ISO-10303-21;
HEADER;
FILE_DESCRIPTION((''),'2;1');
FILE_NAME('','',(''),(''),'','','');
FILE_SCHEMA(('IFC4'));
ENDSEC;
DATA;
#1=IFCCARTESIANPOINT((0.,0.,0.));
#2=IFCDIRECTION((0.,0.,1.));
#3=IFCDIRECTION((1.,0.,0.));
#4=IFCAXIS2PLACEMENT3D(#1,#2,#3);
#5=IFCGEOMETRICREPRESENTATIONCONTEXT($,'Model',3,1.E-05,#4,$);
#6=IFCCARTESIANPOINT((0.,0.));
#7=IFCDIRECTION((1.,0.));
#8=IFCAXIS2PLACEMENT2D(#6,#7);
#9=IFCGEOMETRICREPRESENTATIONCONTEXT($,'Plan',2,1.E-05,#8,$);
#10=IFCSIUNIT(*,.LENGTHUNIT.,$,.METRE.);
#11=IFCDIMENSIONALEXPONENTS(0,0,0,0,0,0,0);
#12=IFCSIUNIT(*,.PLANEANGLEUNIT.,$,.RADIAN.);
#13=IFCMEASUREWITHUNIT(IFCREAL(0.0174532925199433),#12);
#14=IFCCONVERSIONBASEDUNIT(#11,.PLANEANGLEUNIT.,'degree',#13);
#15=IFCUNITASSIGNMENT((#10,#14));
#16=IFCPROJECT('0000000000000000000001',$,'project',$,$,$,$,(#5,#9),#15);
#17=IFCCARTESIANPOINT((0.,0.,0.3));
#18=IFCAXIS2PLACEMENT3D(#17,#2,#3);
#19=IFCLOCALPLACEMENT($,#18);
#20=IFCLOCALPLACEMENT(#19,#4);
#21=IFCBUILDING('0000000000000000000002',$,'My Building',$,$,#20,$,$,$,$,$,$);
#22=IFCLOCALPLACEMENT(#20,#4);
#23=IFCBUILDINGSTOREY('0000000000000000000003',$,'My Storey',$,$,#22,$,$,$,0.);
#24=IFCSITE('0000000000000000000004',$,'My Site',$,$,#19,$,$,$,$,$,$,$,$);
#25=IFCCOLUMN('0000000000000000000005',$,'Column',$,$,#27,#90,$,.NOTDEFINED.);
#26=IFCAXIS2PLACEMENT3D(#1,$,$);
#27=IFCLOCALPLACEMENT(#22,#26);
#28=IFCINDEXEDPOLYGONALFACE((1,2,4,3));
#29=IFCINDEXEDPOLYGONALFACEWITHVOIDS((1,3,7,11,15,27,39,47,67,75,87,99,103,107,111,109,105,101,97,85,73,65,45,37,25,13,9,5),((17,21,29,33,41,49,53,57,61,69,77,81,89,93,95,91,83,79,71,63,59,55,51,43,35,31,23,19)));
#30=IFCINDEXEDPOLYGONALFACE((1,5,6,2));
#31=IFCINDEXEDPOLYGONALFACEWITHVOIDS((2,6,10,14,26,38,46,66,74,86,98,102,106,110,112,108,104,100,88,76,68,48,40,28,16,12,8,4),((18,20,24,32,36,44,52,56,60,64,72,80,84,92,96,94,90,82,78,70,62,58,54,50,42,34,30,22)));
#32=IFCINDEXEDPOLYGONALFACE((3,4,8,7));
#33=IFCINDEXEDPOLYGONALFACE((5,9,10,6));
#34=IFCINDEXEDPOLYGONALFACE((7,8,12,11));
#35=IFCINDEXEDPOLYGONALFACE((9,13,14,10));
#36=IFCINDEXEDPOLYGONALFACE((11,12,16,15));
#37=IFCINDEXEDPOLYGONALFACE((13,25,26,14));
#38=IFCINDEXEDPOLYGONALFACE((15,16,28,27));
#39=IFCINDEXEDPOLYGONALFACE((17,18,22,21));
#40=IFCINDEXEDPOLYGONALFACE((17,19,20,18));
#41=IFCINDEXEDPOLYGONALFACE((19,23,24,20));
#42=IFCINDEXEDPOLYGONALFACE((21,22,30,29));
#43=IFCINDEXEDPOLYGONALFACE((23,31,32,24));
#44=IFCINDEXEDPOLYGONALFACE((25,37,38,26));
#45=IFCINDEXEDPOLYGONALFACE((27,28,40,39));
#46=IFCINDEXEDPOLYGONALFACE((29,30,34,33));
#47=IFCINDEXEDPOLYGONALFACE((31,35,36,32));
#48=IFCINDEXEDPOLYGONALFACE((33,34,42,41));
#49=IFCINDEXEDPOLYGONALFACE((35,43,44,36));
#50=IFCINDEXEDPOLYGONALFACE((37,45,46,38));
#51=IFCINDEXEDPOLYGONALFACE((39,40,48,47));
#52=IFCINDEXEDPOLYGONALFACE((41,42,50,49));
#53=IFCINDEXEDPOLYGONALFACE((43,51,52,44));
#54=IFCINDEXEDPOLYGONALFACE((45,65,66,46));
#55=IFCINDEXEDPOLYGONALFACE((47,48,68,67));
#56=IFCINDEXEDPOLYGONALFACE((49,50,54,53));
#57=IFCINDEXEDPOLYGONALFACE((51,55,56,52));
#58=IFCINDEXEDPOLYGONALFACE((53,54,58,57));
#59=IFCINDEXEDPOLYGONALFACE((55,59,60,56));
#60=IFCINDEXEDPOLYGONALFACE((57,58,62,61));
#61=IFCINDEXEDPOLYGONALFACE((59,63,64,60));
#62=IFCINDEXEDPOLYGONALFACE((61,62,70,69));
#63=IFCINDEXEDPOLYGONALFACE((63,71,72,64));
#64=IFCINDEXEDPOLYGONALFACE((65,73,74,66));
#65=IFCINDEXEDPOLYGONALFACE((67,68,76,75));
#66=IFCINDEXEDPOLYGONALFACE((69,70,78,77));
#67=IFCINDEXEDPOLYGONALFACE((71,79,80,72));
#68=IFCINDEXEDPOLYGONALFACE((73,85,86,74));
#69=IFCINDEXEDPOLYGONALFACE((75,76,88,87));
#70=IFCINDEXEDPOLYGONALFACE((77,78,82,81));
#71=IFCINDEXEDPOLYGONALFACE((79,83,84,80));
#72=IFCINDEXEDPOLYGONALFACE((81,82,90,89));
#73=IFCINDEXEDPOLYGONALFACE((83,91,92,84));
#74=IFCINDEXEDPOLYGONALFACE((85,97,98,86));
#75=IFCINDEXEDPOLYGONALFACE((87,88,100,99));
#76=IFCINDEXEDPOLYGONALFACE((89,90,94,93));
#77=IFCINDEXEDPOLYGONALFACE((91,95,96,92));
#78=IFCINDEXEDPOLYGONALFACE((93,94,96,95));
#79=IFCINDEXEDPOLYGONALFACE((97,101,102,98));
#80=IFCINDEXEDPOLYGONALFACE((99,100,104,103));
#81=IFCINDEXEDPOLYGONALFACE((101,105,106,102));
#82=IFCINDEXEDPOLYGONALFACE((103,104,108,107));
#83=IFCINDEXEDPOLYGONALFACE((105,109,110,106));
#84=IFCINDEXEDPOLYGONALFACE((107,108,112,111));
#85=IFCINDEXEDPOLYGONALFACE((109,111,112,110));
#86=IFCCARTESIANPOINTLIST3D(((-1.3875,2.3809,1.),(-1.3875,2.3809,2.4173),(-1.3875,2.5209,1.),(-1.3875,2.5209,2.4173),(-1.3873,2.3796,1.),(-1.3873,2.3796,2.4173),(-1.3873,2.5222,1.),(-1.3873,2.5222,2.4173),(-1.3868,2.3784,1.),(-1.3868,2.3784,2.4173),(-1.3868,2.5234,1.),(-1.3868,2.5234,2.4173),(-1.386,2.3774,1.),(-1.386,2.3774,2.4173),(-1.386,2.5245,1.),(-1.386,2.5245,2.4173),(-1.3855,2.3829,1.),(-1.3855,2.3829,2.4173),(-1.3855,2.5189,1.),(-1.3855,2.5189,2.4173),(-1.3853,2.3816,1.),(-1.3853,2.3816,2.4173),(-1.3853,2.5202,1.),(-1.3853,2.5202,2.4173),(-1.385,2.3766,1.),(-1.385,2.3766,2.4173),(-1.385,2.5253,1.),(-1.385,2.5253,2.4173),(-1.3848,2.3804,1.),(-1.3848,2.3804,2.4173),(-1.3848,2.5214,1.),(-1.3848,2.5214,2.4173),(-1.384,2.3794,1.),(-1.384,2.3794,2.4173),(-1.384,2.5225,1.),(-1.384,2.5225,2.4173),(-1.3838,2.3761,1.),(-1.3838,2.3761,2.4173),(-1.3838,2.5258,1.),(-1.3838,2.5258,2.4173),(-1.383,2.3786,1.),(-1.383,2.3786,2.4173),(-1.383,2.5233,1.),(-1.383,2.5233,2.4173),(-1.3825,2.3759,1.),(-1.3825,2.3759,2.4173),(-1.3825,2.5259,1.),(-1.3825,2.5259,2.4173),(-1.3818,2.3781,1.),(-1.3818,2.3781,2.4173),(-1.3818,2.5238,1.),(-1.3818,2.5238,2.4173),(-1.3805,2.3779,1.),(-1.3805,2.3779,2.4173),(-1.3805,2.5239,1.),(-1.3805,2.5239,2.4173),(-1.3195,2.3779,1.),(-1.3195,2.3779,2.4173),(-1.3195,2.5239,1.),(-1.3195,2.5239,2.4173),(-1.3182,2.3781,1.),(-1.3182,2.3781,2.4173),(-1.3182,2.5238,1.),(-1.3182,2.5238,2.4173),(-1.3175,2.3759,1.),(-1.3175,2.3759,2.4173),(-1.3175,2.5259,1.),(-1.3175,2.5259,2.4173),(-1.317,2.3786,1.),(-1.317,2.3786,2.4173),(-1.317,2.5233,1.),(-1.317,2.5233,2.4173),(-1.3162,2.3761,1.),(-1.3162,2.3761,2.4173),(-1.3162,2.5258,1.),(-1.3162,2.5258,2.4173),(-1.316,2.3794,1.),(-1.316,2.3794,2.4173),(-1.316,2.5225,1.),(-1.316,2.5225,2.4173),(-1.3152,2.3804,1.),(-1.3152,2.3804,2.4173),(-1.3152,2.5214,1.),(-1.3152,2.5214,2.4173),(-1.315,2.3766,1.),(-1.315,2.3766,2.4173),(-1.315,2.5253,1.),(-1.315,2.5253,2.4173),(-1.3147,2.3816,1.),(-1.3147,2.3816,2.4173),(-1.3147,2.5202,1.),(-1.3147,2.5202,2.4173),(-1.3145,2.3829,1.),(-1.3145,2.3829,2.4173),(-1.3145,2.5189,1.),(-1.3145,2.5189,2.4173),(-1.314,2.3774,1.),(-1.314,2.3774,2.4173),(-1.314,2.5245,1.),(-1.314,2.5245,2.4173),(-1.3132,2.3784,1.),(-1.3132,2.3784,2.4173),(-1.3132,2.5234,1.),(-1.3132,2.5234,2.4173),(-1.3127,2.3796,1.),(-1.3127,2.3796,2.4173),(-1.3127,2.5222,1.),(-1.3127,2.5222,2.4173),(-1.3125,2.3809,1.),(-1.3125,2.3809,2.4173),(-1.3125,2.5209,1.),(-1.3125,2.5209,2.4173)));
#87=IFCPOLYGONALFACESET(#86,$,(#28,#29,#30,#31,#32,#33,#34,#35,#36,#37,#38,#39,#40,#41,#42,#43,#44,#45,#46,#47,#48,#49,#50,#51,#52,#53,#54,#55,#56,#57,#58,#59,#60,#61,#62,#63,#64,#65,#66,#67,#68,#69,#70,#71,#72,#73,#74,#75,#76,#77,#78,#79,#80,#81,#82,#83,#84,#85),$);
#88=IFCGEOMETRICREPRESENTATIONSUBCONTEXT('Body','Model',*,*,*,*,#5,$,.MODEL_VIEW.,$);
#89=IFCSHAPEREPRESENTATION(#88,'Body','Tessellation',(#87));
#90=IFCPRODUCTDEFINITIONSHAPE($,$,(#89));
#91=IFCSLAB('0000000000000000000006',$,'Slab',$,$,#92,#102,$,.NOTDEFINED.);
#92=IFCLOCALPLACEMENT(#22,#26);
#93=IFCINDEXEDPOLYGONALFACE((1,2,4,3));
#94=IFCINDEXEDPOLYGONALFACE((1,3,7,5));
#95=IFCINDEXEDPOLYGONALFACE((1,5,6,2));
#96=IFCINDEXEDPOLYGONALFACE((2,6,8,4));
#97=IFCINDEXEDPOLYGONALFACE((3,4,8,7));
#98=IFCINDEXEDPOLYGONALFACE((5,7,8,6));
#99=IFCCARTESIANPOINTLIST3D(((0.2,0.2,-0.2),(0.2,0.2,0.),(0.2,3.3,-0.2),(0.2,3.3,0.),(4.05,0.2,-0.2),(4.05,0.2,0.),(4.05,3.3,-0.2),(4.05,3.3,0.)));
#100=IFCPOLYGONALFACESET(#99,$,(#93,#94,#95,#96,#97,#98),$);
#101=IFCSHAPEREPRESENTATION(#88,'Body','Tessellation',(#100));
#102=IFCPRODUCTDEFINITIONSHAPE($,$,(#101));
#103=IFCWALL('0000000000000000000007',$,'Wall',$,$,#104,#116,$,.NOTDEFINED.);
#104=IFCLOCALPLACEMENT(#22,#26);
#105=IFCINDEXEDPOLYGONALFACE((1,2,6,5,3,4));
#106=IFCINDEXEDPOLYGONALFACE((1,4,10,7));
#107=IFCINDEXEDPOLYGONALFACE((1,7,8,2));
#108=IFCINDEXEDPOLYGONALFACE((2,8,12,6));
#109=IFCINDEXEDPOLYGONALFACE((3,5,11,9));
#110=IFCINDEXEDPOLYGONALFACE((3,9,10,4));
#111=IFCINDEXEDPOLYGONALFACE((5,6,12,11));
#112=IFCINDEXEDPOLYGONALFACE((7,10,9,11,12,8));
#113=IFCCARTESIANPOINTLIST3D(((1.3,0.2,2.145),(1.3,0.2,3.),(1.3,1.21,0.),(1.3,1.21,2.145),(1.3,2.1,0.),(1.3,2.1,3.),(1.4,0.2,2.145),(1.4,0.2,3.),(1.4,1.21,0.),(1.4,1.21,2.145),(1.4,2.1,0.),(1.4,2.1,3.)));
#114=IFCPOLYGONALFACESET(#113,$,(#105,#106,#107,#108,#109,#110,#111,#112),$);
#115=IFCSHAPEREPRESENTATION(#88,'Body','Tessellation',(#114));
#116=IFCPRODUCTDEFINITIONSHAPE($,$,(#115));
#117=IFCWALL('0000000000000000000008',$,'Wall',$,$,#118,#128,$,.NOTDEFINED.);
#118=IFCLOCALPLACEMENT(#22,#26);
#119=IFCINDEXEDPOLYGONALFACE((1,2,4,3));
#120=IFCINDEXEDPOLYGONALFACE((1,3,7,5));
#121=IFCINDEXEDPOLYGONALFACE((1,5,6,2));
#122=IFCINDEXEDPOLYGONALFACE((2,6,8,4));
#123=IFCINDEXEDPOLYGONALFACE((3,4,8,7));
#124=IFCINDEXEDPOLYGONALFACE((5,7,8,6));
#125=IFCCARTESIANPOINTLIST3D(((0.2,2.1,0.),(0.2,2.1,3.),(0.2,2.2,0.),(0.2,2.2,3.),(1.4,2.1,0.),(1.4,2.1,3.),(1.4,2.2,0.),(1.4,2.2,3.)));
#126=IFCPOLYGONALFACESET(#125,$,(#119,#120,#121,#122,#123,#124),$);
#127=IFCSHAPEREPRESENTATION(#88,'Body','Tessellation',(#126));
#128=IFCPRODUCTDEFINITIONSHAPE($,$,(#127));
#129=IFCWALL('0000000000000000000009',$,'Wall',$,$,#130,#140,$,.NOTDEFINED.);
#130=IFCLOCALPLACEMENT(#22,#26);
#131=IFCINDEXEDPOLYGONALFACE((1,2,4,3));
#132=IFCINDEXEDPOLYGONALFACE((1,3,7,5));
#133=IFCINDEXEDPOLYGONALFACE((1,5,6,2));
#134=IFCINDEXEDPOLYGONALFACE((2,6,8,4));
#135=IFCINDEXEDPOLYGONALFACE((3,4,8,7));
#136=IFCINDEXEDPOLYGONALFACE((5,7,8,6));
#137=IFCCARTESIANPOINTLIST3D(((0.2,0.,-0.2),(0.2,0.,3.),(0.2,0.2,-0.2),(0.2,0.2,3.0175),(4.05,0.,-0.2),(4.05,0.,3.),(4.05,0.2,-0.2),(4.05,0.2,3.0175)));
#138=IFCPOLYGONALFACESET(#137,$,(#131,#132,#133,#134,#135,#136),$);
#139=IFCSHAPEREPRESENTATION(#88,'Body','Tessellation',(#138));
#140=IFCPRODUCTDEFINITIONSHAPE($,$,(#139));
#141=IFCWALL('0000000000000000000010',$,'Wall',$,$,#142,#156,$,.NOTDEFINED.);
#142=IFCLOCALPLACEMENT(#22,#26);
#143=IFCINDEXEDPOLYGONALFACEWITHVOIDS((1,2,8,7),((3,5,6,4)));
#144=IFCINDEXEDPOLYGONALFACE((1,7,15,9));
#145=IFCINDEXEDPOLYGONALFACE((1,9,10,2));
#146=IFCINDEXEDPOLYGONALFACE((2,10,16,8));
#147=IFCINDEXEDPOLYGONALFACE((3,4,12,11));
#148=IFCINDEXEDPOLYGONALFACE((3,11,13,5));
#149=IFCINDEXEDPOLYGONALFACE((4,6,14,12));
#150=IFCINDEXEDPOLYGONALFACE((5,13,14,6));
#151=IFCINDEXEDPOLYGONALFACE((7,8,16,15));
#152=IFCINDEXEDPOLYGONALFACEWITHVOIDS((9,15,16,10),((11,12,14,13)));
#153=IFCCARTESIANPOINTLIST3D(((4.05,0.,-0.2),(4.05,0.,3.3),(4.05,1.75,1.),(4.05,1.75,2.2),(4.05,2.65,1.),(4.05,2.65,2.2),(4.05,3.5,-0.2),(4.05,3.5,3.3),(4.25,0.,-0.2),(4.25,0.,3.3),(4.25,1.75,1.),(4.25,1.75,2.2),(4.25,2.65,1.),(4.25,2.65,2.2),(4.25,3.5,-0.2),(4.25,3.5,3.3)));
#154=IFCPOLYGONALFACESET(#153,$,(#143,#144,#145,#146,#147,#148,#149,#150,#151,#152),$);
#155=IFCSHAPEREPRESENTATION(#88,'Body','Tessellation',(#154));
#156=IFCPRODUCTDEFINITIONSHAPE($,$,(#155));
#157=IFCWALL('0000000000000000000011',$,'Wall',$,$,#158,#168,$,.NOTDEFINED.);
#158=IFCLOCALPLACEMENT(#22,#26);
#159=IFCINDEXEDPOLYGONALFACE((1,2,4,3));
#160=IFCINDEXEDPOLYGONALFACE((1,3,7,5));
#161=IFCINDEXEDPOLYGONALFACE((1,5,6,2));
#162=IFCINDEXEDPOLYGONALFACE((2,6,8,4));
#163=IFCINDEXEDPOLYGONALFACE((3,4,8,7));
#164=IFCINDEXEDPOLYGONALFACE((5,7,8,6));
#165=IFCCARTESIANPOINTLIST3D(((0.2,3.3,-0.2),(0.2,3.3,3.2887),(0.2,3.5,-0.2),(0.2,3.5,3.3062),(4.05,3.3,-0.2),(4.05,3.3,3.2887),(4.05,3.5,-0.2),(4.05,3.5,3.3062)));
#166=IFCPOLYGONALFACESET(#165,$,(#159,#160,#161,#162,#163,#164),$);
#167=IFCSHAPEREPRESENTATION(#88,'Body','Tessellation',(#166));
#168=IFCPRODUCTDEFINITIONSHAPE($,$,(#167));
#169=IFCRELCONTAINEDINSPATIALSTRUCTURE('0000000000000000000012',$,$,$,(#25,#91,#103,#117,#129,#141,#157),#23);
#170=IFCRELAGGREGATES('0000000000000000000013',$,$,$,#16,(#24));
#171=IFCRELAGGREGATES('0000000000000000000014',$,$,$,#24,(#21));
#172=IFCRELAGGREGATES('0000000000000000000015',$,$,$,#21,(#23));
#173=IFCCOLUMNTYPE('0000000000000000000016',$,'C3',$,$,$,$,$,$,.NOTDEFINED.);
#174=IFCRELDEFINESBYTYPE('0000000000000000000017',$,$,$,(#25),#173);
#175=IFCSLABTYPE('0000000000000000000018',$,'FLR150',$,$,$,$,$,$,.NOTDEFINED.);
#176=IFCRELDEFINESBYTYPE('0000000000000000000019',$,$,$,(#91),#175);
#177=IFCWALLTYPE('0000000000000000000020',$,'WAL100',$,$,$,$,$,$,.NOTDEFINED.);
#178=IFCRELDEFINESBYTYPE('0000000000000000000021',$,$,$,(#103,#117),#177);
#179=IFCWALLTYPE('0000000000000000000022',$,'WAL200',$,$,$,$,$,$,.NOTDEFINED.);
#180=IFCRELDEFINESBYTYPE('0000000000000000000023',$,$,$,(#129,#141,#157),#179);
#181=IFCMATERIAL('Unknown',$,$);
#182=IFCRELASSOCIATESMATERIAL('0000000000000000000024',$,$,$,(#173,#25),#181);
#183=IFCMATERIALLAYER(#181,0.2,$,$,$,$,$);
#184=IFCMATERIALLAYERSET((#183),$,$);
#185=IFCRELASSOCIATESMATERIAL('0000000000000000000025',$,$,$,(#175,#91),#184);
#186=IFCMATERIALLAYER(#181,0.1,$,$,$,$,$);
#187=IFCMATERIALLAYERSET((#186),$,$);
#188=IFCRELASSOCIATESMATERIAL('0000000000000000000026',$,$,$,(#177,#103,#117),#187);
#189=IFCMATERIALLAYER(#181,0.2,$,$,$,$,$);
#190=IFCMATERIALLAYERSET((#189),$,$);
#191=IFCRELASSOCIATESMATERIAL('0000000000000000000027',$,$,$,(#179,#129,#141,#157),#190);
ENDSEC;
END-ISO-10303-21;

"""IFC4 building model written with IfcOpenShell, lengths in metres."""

from ifc_helpers import new_model, entity, si_unit, converted_unit, frame, origin_with_axes, origin_2d_with_axis, place, context, subcontext, project, spatial, line, indexed_curve, hollow_rectangle, outline, extrude, clip, halfspace, source, transform, mapped, material, layer, layer_set, layer_usage, material_profile, profile_set, profile_usage, type_object, element, save


model = new_model("IFC4")

# Units and contexts
model_context = context("Model", 3, precision=1e-05, world=origin_with_axes())
plan_context = context("Plan", 2, precision=1e-05, world=origin_2d_with_axis())
body_context = subcontext(model_context, "Body", "Model", "MODEL_VIEW")
ifc_project = project(units=[si_unit("LENGTHUNIT", "METRE"), converted_unit("PLANEANGLEUNIT", "degree", entity("IfcReal", 0.0174532925199433), si_unit("PLANEANGLEUNIT", "RADIAN"), dimensions=[0, 0, 0, 0, 0, 0, 0])], contexts=[model_context, plan_context])

# Site, building, storey
site_placement = place(None, frame((0.0, 0.0, 0.3), z_axis=(0.0, 0.0, 1.0), x_axis=(1.0, 0.0, 0.0)))
site = spatial("IfcSite", under=ifc_project, at=site_placement, Name="My Site")
building_placement = place(site_placement, origin_with_axes())
building = spatial("IfcBuilding", under=site, at=building_placement, Name="My Building")
storey_placement = place(building_placement, origin_with_axes())
storey = spatial("IfcBuildingStorey", under=building, at=storey_placement, Name="My Storey", Elevation=0.0)

# Column
ifc_material = material(Name="Unknown")
ifc_material_profile = material_profile(ifc_material, hollow_rectangle(XDim=0.075, YDim=0.15, WallThickness=0.002, InnerFilletRadius=0.005, OuterFilletRadius=0.005))
ifc_profile_set = profile_set([ifc_material_profile])
ifc_profile_usage = profile_usage(ifc_profile_set, cardinal=5)
column_type = type_object("IfcColumnType", Name="C3", PredefinedType="NOTDEFINED", material=ifc_profile_set)
column_placement = place(storey_placement, frame((-1.35, 2.4509, 1.0), z_axis=(0.0, 0.0, 1.0), x_axis=(1.0, 0.0, 0.0)))
element("IfcColumn", 1, at=column_placement, inside=storey, type_object=column_type, material=ifc_profile_usage, Name="Column", PredefinedType="NOTDEFINED", context=body_context, shape_type="SweptSolid", body=[
    extrude(hollow_rectangle(XDim=0.075, YDim=0.15, WallThickness=0.002, InnerFilletRadius=0.005, OuterFilletRadius=0.005), origin_with_axes(), (0.0, 0.0, 1.0), 1.4173),
])

# Slab
ifc_layer_1 = layer(ifc_material, 0.2)
ifc_layer_set_1 = layer_set([ifc_layer_1])
ifc_layer_usage_1 = layer_usage(ifc_layer_set_1, "AXIS3", "POSITIVE", 0.0)
slab_type_1 = type_object("IfcSlabType", Name="FLR150", PredefinedType="NOTDEFINED", material=ifc_layer_set_1)
slab_1_placement = place(storey_placement, frame((0.2, 0.2, -0.2), z_axis=(0.0, 0.0, 1.0), x_axis=(1.0, 0.0, 0.0)))
element("IfcSlab", 2, at=slab_1_placement, inside=storey, type_object=slab_type_1, material=ifc_layer_usage_1, Name="Slab", PredefinedType="NOTDEFINED", context=body_context, shape_type="SweptSolid", body=[
    extrude(outline(indexed_curve([(0.0, 0.0), (3.85, 0.0), (3.85, 3.1), (0.0, 3.1)], segments=[line(4, 1), line(1, 2), line(2, 3), line(3, 4)], self_intersect=False)), None, (0.0, 0.0, 1.0), 0.2),
])

# Wall, opening
ifc_layer_2 = layer(ifc_material, 0.1)
ifc_layer_set_2 = layer_set([ifc_layer_2])
ifc_layer_usage_2 = layer_usage(ifc_layer_set_2, "AXIS2", "POSITIVE", 0.0)
wall_type_1 = type_object("IfcWallType", Name="WAL100", PredefinedType="NOTDEFINED", material=ifc_layer_set_2)
wall_1_placement = place(storey_placement, frame((1.4, 0.2, 0.0), z_axis=(0.0, 0.0, 1.0), x_axis=(0.0, 1.0, 0.0)))
wall_1 = element("IfcWall", 3, at=wall_1_placement, inside=storey, type_object=wall_type_1, material=ifc_layer_usage_2, Name="Wall", PredefinedType="NOTDEFINED", context=body_context, shape_type="SweptSolid", body=[
    extrude(outline(indexed_curve([(0.0, 0.0), (0.0, 0.1), (1.9, 0.1), (1.9, 0.0), (0.0, 0.0)], self_intersect=False)), origin_with_axes(), (0.0, 0.0, 1.0), 3.0),
])
shared_shape_1 = source(origin_with_axes(), body_context, "Body", "SweptSolid", [
    extrude(outline(indexed_curve([(0.0, 0.0), (1.01, 0.0), (1.01, 2.145), (0.0, 2.145)], segments=[line(1, 2), line(2, 3), line(3, 4), line(4, 1)])), frame((0.0, -0.1, 0.0), z_axis=(0.0, -1.0, 0.0), x_axis=(1.0, 0.0, 0.0)), (0.0, 0.0, -1.0), 0.4),
])
opening_1_placement = place(wall_1_placement, origin_with_axes())
element("IfcOpeningElement", 4, at=opening_1_placement, cuts=wall_1, PredefinedType="OPENING", context=body_context, shape_type="MappedRepresentation", body=[
    mapped(shared_shape_1, transform((0.0, 0.0, 0.0), x_axis=(1.0, 0.0, 0.0), y_axis=(0.0, 1.0, 0.0), z_axis=(0.0, 0.0, 1.0), scale=1.0)),
])

# Walls
ifc_layer_usage_3 = layer_usage(ifc_layer_set_2, "AXIS2", "POSITIVE", 0.0)
wall_2_placement = place(storey_placement, frame((0.2, 2.1, 0.0), z_axis=(0.0, 0.0, 1.0), x_axis=(1.0, 0.0, 0.0)))
element("IfcWall", 5, at=wall_2_placement, inside=storey, type_object=wall_type_1, material=ifc_layer_usage_3, Name="Wall", PredefinedType="NOTDEFINED", context=body_context, shape_type="SweptSolid", body=[
    extrude(outline(indexed_curve([(0.0, 0.0), (0.0, 0.1), (1.2, 0.1), (1.2, 0.0), (0.0, 0.0)], self_intersect=False)), origin_with_axes(), (0.0, 0.0, 1.0), 3.0),
])
ifc_layer_3 = layer(ifc_material, 0.2)
ifc_layer_set_3 = layer_set([ifc_layer_3])
ifc_layer_usage_4 = layer_usage(ifc_layer_set_3, "AXIS2", "POSITIVE", 0.0)
wall_type_2 = type_object("IfcWallType", Name="WAL200", PredefinedType="NOTDEFINED", material=ifc_layer_set_3)
wall_3_placement = place(storey_placement, frame((0.2, 0.0, -0.2), z_axis=(0.0, 0.0, 1.0), x_axis=(1.0, 0.0, 0.0)))
element("IfcWall", 6, at=wall_3_placement, inside=storey, type_object=wall_type_2, material=ifc_layer_usage_4, Name="Wall", PredefinedType="NOTDEFINED", context=body_context, shape_type="Clipping", body=[
    clip(extrude(outline(indexed_curve([(0.0, 0.0), (0.0, 0.2), (3.85, 0.2), (3.85, 0.0), (0.0, 0.0)], self_intersect=False)), origin_with_axes(), (0.0, 0.0, 1.0), 3.3175), halfspace(frame((0.0, 0.2, 3.2175), z_axis=(0.0, -0.087156, 0.996195), x_axis=(1.0, 0.0, 0.0)), False)),
])

# Wall, opening
ifc_layer_usage_5 = layer_usage(ifc_layer_set_3, "AXIS2", "POSITIVE", 0.0)
wall_4_placement = place(storey_placement, frame((4.25, 0.0, -0.2), z_axis=(0.0, 0.0, 1.0), x_axis=(0.0, 1.0, 0.0)))
wall_4 = element("IfcWall", 7, at=wall_4_placement, inside=storey, type_object=wall_type_2, material=ifc_layer_usage_5, Name="Wall", PredefinedType="NOTDEFINED", context=body_context, shape_type="SweptSolid", body=[
    extrude(outline(indexed_curve([(0.0, 0.0), (0.0, 0.2), (3.5, 0.2), (3.5, 0.0), (0.0, 0.0)], self_intersect=False)), origin_with_axes(), (0.0, 0.0, 1.0), 3.5),
])
shared_shape_2 = source(origin_with_axes(), body_context, "Body", "SweptSolid", [
    extrude(outline(indexed_curve([(0.0, 0.0), (0.9, 0.0), (0.9, 1.2), (0.0, 1.2)], segments=[line(1, 2), line(2, 3), line(3, 4), line(4, 1)])), frame((0.0, -0.1, 0.0), z_axis=(0.0, -1.0, 0.0), x_axis=(1.0, 0.0, 0.0)), (0.0, 0.0, -1.0), 0.4),
])
opening_2_placement = place(wall_4_placement, frame((1.75, 0.0, 1.2), z_axis=(0.0, 0.0, 1.0), x_axis=(1.0, 0.0, 0.0)))
element("IfcOpeningElement", 8, at=opening_2_placement, cuts=wall_4, PredefinedType="OPENING", context=body_context, shape_type="MappedRepresentation", body=[
    mapped(shared_shape_2, transform((0.0, 0.0, 0.0), x_axis=(1.0, 0.0, 0.0), y_axis=(0.0, 1.0, 0.0), z_axis=(0.0, 0.0, 1.0), scale=1.0)),
])

# Wall
ifc_layer_usage_6 = layer_usage(ifc_layer_set_3, "AXIS2", "POSITIVE", 0.0)
wall_5_placement = place(storey_placement, frame((4.05, 3.5, -0.2), z_axis=(0.0, 0.0, 1.0), x_axis=(-1.0, 0.0, 0.0)))
element("IfcWall", 9, at=wall_5_placement, inside=storey, type_object=wall_type_2, material=ifc_layer_usage_6, Name="Wall", PredefinedType="NOTDEFINED", context=body_context, shape_type="Clipping", body=[
    clip(extrude(outline(indexed_curve([(0.0, 0.0), (0.0, 0.2), (3.85, 0.2), (3.85, 0.0), (0.0, 0.0)], self_intersect=False)), origin_with_axes(), (0.0, 0.0, 1.0), 3.6062), halfspace(frame((0.0, 0.0, 3.5062), z_axis=(0.0, 0.087156, 0.996195), x_axis=(-1.0, 0.0, 0.0)), False)),
])

save(model, "model.ifc")
